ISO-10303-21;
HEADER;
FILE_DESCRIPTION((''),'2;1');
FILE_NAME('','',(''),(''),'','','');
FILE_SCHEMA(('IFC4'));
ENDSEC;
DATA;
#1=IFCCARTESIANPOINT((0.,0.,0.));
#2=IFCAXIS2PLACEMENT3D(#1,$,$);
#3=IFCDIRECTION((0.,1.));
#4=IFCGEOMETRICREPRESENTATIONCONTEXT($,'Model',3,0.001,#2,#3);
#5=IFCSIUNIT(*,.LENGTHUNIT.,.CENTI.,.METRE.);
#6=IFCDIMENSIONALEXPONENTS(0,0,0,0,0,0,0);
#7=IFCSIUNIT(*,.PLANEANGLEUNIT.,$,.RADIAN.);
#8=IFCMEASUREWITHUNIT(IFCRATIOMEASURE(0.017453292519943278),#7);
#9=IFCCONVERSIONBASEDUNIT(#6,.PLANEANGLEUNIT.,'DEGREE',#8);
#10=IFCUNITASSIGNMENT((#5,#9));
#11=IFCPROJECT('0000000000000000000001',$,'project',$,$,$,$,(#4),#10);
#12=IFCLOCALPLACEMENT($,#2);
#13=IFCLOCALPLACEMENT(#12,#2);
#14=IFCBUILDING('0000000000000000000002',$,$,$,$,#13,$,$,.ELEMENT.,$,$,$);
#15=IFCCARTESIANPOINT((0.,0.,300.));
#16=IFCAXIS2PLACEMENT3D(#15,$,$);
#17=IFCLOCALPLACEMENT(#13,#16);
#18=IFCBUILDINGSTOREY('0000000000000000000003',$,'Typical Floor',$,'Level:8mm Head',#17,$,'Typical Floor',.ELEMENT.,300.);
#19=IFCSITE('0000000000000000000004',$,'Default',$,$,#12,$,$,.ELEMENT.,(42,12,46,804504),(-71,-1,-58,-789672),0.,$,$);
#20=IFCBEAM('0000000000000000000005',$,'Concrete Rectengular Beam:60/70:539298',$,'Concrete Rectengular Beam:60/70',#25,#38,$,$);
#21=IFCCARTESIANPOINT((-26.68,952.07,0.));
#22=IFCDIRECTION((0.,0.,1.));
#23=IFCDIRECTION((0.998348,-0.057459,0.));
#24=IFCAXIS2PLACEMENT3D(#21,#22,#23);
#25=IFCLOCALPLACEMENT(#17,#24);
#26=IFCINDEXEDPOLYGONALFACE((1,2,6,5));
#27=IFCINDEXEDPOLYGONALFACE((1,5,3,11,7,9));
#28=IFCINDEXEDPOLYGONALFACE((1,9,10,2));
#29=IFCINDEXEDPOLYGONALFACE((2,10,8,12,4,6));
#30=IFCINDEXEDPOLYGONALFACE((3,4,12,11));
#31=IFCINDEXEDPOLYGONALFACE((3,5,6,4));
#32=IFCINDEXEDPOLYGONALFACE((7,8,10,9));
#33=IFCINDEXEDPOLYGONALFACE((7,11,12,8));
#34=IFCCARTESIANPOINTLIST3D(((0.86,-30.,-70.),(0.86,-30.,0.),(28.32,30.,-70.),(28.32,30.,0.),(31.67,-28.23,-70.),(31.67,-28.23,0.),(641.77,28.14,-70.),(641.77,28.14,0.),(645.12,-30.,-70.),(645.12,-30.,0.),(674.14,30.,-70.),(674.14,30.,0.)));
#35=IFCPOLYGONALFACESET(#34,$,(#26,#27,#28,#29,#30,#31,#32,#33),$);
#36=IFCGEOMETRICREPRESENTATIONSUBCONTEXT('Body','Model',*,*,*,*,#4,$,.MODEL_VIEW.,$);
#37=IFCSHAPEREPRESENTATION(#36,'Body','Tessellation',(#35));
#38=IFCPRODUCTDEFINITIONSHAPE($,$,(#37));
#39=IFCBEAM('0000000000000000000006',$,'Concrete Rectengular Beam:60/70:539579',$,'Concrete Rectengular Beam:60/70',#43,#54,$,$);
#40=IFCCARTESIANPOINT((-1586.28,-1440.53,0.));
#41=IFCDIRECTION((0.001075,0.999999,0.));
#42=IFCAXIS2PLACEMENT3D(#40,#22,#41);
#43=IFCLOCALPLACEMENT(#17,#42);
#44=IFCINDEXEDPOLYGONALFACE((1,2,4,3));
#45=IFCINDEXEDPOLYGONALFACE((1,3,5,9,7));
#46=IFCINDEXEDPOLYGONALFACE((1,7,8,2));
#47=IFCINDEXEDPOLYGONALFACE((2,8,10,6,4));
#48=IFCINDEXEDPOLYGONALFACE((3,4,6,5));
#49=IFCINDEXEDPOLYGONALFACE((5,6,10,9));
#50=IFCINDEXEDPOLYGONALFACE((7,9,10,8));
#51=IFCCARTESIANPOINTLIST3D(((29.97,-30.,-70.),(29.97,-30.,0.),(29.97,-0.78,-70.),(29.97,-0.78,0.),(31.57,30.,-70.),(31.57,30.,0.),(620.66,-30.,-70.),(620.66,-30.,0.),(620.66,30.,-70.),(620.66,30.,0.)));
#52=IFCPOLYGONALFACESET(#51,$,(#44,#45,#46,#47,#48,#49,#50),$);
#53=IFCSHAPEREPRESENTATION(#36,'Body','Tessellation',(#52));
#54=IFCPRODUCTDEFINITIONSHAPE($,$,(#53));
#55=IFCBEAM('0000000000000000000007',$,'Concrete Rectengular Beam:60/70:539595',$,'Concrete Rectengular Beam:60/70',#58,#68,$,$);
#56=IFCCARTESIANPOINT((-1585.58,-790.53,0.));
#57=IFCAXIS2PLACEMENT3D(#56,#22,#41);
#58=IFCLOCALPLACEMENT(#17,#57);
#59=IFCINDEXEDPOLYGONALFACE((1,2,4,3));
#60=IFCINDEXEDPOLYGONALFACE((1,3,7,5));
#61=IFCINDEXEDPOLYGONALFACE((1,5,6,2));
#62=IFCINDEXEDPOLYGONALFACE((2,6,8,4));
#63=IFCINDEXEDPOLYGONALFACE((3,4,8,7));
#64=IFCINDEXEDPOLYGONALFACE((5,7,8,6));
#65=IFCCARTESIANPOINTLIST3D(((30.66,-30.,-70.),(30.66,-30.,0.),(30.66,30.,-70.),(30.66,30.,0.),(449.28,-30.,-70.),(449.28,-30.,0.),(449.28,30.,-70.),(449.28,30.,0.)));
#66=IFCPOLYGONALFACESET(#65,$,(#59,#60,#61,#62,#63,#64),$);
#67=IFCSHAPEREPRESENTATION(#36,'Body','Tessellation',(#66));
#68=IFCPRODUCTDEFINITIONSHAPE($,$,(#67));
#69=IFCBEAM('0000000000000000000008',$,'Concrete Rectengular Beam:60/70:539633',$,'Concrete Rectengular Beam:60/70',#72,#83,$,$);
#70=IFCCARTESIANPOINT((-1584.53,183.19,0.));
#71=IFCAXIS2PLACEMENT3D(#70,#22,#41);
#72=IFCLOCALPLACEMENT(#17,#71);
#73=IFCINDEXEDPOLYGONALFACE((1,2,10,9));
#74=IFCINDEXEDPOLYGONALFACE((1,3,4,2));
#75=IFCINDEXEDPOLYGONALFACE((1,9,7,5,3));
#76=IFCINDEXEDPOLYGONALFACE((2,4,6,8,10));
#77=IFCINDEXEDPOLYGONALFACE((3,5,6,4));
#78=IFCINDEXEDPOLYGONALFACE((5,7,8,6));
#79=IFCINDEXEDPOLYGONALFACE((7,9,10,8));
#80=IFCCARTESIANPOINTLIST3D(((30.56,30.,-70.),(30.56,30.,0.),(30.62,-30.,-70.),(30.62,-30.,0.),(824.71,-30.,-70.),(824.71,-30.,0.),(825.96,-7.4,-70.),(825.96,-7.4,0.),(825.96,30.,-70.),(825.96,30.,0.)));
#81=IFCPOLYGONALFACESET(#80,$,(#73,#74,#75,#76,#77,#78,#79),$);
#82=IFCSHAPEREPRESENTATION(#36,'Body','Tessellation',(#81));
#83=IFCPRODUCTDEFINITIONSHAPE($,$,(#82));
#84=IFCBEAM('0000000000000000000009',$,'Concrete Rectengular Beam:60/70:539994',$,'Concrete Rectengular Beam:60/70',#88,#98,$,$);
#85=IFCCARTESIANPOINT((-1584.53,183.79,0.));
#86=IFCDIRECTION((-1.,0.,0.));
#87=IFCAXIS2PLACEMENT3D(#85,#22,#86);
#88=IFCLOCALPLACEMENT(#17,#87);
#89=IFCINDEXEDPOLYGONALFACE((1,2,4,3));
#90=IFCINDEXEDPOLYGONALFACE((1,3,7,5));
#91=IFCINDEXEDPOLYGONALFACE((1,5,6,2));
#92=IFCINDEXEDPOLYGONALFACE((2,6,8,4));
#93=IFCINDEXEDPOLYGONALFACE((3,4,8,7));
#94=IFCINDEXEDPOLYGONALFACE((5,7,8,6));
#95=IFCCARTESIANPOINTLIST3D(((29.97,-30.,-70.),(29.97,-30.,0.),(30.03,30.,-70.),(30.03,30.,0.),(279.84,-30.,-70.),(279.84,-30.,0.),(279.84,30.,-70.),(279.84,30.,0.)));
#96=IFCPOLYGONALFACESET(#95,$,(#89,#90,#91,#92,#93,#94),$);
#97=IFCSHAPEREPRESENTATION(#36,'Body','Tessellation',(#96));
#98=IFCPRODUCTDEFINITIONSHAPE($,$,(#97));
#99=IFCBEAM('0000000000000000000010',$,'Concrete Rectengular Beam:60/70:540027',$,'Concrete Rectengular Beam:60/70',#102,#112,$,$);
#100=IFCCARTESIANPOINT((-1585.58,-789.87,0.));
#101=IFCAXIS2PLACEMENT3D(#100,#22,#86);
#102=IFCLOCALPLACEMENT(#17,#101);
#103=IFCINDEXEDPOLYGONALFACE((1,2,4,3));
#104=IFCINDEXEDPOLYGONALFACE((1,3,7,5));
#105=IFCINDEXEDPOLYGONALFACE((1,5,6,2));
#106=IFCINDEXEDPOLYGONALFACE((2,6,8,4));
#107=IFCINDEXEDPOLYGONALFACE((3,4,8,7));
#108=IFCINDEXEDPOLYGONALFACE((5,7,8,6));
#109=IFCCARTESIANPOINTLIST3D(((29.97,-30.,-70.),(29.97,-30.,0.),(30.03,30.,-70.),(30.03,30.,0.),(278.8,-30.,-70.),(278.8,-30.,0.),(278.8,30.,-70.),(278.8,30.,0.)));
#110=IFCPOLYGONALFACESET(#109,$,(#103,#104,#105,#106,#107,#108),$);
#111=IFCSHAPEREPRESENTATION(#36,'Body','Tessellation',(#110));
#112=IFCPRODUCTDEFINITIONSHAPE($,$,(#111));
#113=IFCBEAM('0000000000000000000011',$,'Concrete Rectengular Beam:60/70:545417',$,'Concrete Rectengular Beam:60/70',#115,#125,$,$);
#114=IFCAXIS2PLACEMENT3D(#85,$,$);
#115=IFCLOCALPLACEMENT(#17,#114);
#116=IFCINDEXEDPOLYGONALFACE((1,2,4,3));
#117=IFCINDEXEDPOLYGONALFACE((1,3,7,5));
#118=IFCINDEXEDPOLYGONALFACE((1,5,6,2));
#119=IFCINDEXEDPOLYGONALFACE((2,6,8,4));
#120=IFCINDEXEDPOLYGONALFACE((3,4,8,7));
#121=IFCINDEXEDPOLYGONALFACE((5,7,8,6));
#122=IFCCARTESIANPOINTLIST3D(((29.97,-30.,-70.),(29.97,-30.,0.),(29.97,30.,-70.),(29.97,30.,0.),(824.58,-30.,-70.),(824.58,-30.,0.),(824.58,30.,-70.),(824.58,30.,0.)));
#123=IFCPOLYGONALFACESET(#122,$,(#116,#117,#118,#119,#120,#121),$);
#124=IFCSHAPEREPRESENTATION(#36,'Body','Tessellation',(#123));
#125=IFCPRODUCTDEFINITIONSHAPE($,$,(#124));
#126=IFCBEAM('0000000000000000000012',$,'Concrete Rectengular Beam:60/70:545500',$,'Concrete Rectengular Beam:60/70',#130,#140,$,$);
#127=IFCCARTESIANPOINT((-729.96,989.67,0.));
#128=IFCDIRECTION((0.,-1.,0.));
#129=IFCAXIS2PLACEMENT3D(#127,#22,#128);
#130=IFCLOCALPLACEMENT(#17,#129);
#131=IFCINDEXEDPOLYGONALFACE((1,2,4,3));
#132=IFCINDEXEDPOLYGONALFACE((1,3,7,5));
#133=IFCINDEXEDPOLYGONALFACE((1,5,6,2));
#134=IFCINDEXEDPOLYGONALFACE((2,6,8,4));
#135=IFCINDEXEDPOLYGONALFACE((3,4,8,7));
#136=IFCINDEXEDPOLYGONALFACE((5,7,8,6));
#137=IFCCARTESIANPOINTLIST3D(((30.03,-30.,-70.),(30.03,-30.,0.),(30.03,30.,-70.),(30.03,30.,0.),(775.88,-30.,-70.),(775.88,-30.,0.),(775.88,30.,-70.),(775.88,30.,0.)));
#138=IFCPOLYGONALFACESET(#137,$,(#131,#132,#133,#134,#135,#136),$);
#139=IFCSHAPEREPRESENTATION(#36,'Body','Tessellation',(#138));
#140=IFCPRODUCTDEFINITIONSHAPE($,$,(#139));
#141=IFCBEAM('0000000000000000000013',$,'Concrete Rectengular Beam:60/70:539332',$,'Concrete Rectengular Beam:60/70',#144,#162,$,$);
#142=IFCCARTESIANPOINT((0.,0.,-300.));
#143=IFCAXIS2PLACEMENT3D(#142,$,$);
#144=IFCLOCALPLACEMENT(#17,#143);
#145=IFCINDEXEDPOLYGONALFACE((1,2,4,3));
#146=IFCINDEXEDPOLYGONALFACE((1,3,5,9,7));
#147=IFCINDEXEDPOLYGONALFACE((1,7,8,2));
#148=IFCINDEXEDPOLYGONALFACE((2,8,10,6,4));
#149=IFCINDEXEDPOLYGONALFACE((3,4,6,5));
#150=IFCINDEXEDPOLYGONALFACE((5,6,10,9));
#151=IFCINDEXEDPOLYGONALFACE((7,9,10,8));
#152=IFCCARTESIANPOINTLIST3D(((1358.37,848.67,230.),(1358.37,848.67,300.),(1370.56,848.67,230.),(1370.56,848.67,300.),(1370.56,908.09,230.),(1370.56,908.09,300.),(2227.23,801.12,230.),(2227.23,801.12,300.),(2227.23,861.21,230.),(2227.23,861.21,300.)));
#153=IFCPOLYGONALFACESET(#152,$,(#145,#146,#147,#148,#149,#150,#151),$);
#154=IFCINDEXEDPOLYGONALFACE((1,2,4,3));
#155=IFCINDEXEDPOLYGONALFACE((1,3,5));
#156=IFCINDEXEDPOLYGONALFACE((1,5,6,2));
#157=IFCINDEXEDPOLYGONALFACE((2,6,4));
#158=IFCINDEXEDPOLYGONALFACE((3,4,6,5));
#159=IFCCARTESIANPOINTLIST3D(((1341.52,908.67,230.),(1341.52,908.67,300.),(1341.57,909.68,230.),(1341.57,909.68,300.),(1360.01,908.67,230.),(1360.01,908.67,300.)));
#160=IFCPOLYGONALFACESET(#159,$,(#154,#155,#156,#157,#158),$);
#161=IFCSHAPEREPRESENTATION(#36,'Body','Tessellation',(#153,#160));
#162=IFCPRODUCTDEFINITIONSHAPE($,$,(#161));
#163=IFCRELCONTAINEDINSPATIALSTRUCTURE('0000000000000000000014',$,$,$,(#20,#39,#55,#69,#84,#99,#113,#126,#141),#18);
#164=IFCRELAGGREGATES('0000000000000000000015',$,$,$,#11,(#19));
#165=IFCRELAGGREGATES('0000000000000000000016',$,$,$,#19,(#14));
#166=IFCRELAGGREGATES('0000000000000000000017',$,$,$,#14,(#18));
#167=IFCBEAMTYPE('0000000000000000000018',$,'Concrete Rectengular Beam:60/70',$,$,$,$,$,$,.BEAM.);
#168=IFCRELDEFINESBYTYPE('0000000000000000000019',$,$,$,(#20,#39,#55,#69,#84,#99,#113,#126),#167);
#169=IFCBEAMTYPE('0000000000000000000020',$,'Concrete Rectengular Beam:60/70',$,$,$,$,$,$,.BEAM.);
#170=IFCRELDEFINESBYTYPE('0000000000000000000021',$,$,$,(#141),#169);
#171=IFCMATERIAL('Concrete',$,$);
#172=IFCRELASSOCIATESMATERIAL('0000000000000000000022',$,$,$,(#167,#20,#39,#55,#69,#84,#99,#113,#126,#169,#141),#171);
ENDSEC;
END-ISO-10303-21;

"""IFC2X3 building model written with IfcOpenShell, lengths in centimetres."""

from ifc_helpers import new_model, entity, si_unit, converted_unit, direction, frame, frame_2d, origin, origin_2d_with_axis, place, context, subcontext, project, spatial, polyline, rectangle, extrude, clip, halfspace, bounded_halfspace, source, transform, mapped, material, type_object, type_shapes, element, save


model = new_model("IFC2X3")

# Units and contexts
model_context = context("Model", 3, precision=0.001, world=origin(), true_north=direction((0.0, 1.0)))
body_context = subcontext(model_context, "Body", "Model", "MODEL_VIEW")
ifc_project = project(units=[si_unit("LENGTHUNIT", "METRE", prefix="CENTI"), converted_unit("PLANEANGLEUNIT", "DEGREE", entity("IfcRatioMeasure", 0.017453292519943278), si_unit("PLANEANGLEUNIT", "RADIAN"), dimensions=[0, 0, 0, 0, 0, 0, 0])], contexts=[model_context])

# Site, building, storey
site_placement = place(None, origin())
site = spatial("IfcSite", under=ifc_project, at=site_placement, Name="Default", CompositionType="ELEMENT", RefLatitude=(42, 12, 46, 804504), RefLongitude=(-71, -1, -58, -789672), RefElevation=0.0)
building_placement = place(site_placement, origin())
building = spatial("IfcBuilding", under=site, at=building_placement, CompositionType="ELEMENT")
storey_placement = place(building_placement, frame((0.0, 0.0, 300.0)))
storey = spatial("IfcBuildingStorey", under=building, at=storey_placement, Name="Typical Floor", ObjectType="Level:8mm Head", LongName="Typical Floor", CompositionType="ELEMENT", Elevation=300.0)

# Beams
ifc_material = material(Name="Concrete")
beam_type_1 = type_object("IfcBeamType", Name="Concrete Rectengular Beam:60/70", PredefinedType="BEAM", material=ifc_material)
beam_1_placement = place(storey_placement, frame((-26.68, 952.07, 0.0), z_axis=(0.0, 0.0, 1.0), x_axis=(0.998348, -0.057459, 0.0)))
element("IfcBeam", 1, at=beam_1_placement, inside=storey, type_object=beam_type_1, material=ifc_material, Name="Concrete Rectengular Beam:60/70:539298", ObjectType="Concrete Rectengular Beam:60/70", context=body_context, shape_type="SweptSolid", body=[
    clip(clip(clip(clip(extrude(rectangle(XDim=70.0, YDim=60.0, at=origin_2d_with_axis()), frame((0.86, 0.0, -35.0), z_axis=(1.0, 0.0, 0.0), x_axis=(0.0, 0.0, -1.0)), (0.0, 0.0, 1.0), 673.28), bounded_halfspace(frame((31.67, -28.23, 0.0), z_axis=(-0.998348, -0.057459, 0.0), x_axis=(0.0, 0.0, -1.0)), False, frame((0.86, 0.0, -35.0), z_axis=(1.0, 0.0, 0.0), x_axis=(0.0, 0.0, -1.0)), polyline([(35.0, -28.23), (-35.0, -28.23), (-35.0, 30.0), (35.0, 30.0), (35.0, -28.23)]))), bounded_halfspace(frame((-28.23, -31.67, 0.0), z_axis=(-0.057459, 0.998348, 0.0), x_axis=(0.0, 0.0, -1.0)), False, frame((0.86, 0.0, -35.0), z_axis=(1.0, 0.0, 0.0), x_axis=(0.0, 0.0, -1.0)), polyline([(-35.0, -28.23), (35.0, -28.23), (35.0, -30.0), (-35.0, -30.0), (-35.0, -28.23)]))), bounded_halfspace(frame((701.67, 31.58, 0.0), z_axis=(0.057459, -0.998348, 0.0), x_axis=(0.0, 0.0, -1.0)), False, frame((0.86, 0.0, -35.0), z_axis=(1.0, 0.0, 0.0), x_axis=(0.0, 0.0, -1.0)), polyline([(-35.0, 28.14), (35.0, 28.14), (35.0, 30.0), (-35.0, 30.0), (-35.0, 28.14)]))), bounded_halfspace(frame((641.77, 28.14, 0.0), z_axis=(0.998348, 0.057459, 0.0), x_axis=(0.0, 0.0, -1.0)), False, frame((0.86, 0.0, -35.0), z_axis=(1.0, 0.0, 0.0), x_axis=(0.0, 0.0, -1.0)), polyline([(35.0, 28.14), (-35.0, 28.14), (-35.0, -30.0), (-15.0, -30.0), (35.0, -30.0), (35.0, 28.14)]))),
])
beam_2_placement = place(storey_placement, frame((-1586.28, -1440.53, 0.0), z_axis=(0.0, 0.0, 1.0), x_axis=(0.001075, 0.999999, 0.0)))
element("IfcBeam", 2, at=beam_2_placement, inside=storey, type_object=beam_type_1, material=ifc_material, Name="Concrete Rectengular Beam:60/70:539579", ObjectType="Concrete Rectengular Beam:60/70", context=body_context, shape_type="SweptSolid", body=[
    clip(extrude(rectangle(XDim=70.0, YDim=60.0, at=frame_2d((0.0, 0.0), x_axis=(1.0, 0.0))), frame((29.97, 0.0, -35.0), z_axis=(1.0, 0.0, 0.0), x_axis=(0.0, 0.0, -1.0)), (0.0, 0.0, 1.0), 590.69), halfspace(frame((43.3, 255.34, 0.0), z_axis=(-0.998648, 0.051987, 0.0), x_axis=(-0.051987, -0.998648, 0.0)), False)),
])
beam_3_placement = place(storey_placement, frame((-1585.58, -790.53, 0.0), z_axis=(0.0, 0.0, 1.0), x_axis=(0.001075, 0.999999, 0.0)))
element("IfcBeam", 3, at=beam_3_placement, inside=storey, type_object=beam_type_1, material=ifc_material, Name="Concrete Rectengular Beam:60/70:539595", ObjectType="Concrete Rectengular Beam:60/70", context=body_context, shape_type="SweptSolid", body=[
    extrude(rectangle(XDim=70.0, YDim=60.0, at=frame_2d((0.0, 0.0), x_axis=(1.0, 0.0))), frame((30.66, 0.0, -35.0), z_axis=(1.0, 0.0, 0.0), x_axis=(0.0, 0.0, -1.0)), (0.0, 0.0, 1.0), 418.62),
])
beam_4_placement = place(storey_placement, frame((-1584.53, 183.19, 0.0), z_axis=(0.0, 0.0, 1.0), x_axis=(0.001075, 0.999999, 0.0)))
element("IfcBeam", 4, at=beam_4_placement, inside=storey, type_object=beam_type_1, material=ifc_material, Name="Concrete Rectengular Beam:60/70:539633", ObjectType="Concrete Rectengular Beam:60/70", context=body_context, shape_type="SweptSolid", body=[
    clip(clip(extrude(rectangle(XDim=70.0, YDim=60.0, at=frame_2d((0.0, 0.0), x_axis=(1.0, 0.0))), frame((30.56, 0.0, -35.0), z_axis=(1.0, 0.0, 0.0), x_axis=(0.0, 0.0, -1.0)), (0.0, 0.0, 1.0), 795.4), halfspace(frame((30.63, -32.39, -70.0), z_axis=(-0.999999, -0.001075, 0.0), x_axis=(-0.001075, 0.999999, 0.0)), False)), halfspace(frame((781.15, -819.3, 0.0), z_axis=(0.99848, -0.055107, 0.0), x_axis=(0.055107, 0.99848, 0.0)), False)),
])
beam_5_placement = place(storey_placement, frame((-1584.53, 183.79, 0.0), z_axis=(0.0, 0.0, 1.0), x_axis=(-1.0, 0.0, 0.0)))
element("IfcBeam", 5, at=beam_5_placement, inside=storey, type_object=beam_type_1, material=ifc_material, Name="Concrete Rectengular Beam:60/70:539994", ObjectType="Concrete Rectengular Beam:60/70", context=body_context, shape_type="SweptSolid", body=[
    clip(extrude(rectangle(XDim=70.0, YDim=60.0, at=frame_2d((0.0, 0.0), x_axis=(1.0, 0.0))), frame((29.97, 0.0, -35.0), z_axis=(1.0, 0.0, 0.0), x_axis=(0.0, 0.0, -1.0)), (0.0, 0.0, 1.0), 249.88), halfspace(frame((30.03, 31.27, -70.0), z_axis=(-0.999999, 0.001075, 0.0), x_axis=(0.001075, 0.999999, 0.0)), False)),
])
beam_6_placement = place(storey_placement, frame((-1585.58, -789.87, 0.0), z_axis=(0.0, 0.0, 1.0), x_axis=(-1.0, 0.0, 0.0)))
element("IfcBeam", 6, at=beam_6_placement, inside=storey, type_object=beam_type_1, material=ifc_material, Name="Concrete Rectengular Beam:60/70:540027", ObjectType="Concrete Rectengular Beam:60/70", context=body_context, shape_type="SweptSolid", body=[
    clip(extrude(rectangle(XDim=70.0, YDim=60.0, at=frame_2d((0.0, 0.0), x_axis=(1.0, 0.0))), frame((29.97, 0.0, -35.0), z_axis=(1.0, 0.0, 0.0), x_axis=(0.0, 0.0, -1.0)), (0.0, 0.0, 1.0), 248.83), halfspace(frame((30.03, 31.24, -70.0), z_axis=(-0.999999, 0.001075, 0.0), x_axis=(0.001075, 0.999999, 0.0)), False)),
])
beam_7_placement = place(storey_placement, frame((-1584.53, 183.79, 0.0)))
element("IfcBeam", 7, at=beam_7_placement, inside=storey, type_object=beam_type_1, material=ifc_material, Name="Concrete Rectengular Beam:60/70:545417", ObjectType="Concrete Rectengular Beam:60/70", context=body_context, shape_type="SweptSolid", body=[
    extrude(rectangle(XDim=70.0, YDim=60.0, at=frame_2d((0.0, 0.0), x_axis=(1.0, 0.0))), frame((29.97, 0.0, -35.0), z_axis=(1.0, 0.0, 0.0), x_axis=(0.0, 0.0, -1.0)), (0.0, 0.0, 1.0), 794.61),
])
beam_8_placement = place(storey_placement, frame((-729.96, 989.67, 0.0), z_axis=(0.0, 0.0, 1.0), x_axis=(0.0, -1.0, 0.0)))
element("IfcBeam", 8, at=beam_8_placement, inside=storey, type_object=beam_type_1, material=ifc_material, Name="Concrete Rectengular Beam:60/70:545500", ObjectType="Concrete Rectengular Beam:60/70", context=body_context, shape_type="SweptSolid", body=[
    extrude(rectangle(XDim=70.0, YDim=60.0, at=frame_2d((0.0, 0.0), x_axis=(1.0, 0.0))), frame((30.03, 0.0, -35.0), z_axis=(1.0, 0.0, 0.0), x_axis=(0.0, 0.0, -1.0)), (0.0, 0.0, 1.0), 745.85),
])
beam_type_2 = type_object("IfcBeamType", Name="Concrete Rectengular Beam:60/70", PredefinedType="BEAM", material=ifc_material)
shared_shape_1 = source(origin(), body_context, "Body", "SweptSolid", [
    clip(clip(clip(extrude(rectangle(XDim=70.0, YDim=60.0, at=frame_2d((0.0, 0.0), x_axis=(1.0, 0.0))), frame((1360.01, 878.62, 265.0), z_axis=(0.998506, -0.054646, 0.0), x_axis=(0.0, 0.0, -1.0)), (0.0, 0.0, 1.0), 870.16), halfspace(frame((2227.23, 865.34, 300.0), z_axis=(1.0, 0.0, 0.0), x_axis=(0.0, -1.0, 0.0)), False)), bounded_halfspace(frame((1370.56, 848.67, 300.0), z_axis=(-1.0, 0.0, 0.0), x_axis=(0.0, 0.0, -1.0)), False, frame((1360.01, 878.62, 265.0), z_axis=(0.998506, -0.054646, 0.0), x_axis=(0.0, 0.0, -1.0)), polyline([(35.0, -29.33), (-35.0, -29.33), (-35.0, 30.0), (35.0, 30.0), (35.0, -29.33)]))), bounded_halfspace(frame((1310.56, 848.67, 300.0), z_axis=(0.0, 1.0, 0.0), x_axis=(0.0, 0.0, -1.0)), False, frame((1360.01, 878.62, 265.0), z_axis=(0.998506, -0.054646, 0.0), x_axis=(0.0, 0.0, -1.0)), polyline([(-35.0, -29.33), (35.0, -29.33), (35.0, -30.0), (-35.0, -30.0), (-35.0, -29.33)]))),
    clip(extrude(rectangle(XDim=70.0, YDim=1.01, at=frame_2d((0.0, 0.0), x_axis=(1.0, 0.0))), frame((1341.54, 909.17, 265.0), z_axis=(0.998506, -0.054646, 0.0), x_axis=(0.0, 0.0, -1.0)), (0.0, 0.0, 1.0), 18.47), halfspace(frame((1370.56, 908.67, 300.0), z_axis=(0.0, -1.0, 0.0), x_axis=(0.0, 0.0, -1.0)), False)),
])
type_shapes(beam_type_2, [shared_shape_1])
beam_9_placement = place(storey_placement, frame((0.0, 0.0, -300.0)))
element("IfcBeam", 9, at=beam_9_placement, inside=storey, type_object=beam_type_2, material=ifc_material, Name="Concrete Rectengular Beam:60/70:539332", ObjectType="Concrete Rectengular Beam:60/70", context=body_context, shape_type="MappedRepresentation", body=[
    mapped(shared_shape_1, transform((0.0, 0.0, 0.0), scale=1.0)),
])

save(model, "model.ifc")
